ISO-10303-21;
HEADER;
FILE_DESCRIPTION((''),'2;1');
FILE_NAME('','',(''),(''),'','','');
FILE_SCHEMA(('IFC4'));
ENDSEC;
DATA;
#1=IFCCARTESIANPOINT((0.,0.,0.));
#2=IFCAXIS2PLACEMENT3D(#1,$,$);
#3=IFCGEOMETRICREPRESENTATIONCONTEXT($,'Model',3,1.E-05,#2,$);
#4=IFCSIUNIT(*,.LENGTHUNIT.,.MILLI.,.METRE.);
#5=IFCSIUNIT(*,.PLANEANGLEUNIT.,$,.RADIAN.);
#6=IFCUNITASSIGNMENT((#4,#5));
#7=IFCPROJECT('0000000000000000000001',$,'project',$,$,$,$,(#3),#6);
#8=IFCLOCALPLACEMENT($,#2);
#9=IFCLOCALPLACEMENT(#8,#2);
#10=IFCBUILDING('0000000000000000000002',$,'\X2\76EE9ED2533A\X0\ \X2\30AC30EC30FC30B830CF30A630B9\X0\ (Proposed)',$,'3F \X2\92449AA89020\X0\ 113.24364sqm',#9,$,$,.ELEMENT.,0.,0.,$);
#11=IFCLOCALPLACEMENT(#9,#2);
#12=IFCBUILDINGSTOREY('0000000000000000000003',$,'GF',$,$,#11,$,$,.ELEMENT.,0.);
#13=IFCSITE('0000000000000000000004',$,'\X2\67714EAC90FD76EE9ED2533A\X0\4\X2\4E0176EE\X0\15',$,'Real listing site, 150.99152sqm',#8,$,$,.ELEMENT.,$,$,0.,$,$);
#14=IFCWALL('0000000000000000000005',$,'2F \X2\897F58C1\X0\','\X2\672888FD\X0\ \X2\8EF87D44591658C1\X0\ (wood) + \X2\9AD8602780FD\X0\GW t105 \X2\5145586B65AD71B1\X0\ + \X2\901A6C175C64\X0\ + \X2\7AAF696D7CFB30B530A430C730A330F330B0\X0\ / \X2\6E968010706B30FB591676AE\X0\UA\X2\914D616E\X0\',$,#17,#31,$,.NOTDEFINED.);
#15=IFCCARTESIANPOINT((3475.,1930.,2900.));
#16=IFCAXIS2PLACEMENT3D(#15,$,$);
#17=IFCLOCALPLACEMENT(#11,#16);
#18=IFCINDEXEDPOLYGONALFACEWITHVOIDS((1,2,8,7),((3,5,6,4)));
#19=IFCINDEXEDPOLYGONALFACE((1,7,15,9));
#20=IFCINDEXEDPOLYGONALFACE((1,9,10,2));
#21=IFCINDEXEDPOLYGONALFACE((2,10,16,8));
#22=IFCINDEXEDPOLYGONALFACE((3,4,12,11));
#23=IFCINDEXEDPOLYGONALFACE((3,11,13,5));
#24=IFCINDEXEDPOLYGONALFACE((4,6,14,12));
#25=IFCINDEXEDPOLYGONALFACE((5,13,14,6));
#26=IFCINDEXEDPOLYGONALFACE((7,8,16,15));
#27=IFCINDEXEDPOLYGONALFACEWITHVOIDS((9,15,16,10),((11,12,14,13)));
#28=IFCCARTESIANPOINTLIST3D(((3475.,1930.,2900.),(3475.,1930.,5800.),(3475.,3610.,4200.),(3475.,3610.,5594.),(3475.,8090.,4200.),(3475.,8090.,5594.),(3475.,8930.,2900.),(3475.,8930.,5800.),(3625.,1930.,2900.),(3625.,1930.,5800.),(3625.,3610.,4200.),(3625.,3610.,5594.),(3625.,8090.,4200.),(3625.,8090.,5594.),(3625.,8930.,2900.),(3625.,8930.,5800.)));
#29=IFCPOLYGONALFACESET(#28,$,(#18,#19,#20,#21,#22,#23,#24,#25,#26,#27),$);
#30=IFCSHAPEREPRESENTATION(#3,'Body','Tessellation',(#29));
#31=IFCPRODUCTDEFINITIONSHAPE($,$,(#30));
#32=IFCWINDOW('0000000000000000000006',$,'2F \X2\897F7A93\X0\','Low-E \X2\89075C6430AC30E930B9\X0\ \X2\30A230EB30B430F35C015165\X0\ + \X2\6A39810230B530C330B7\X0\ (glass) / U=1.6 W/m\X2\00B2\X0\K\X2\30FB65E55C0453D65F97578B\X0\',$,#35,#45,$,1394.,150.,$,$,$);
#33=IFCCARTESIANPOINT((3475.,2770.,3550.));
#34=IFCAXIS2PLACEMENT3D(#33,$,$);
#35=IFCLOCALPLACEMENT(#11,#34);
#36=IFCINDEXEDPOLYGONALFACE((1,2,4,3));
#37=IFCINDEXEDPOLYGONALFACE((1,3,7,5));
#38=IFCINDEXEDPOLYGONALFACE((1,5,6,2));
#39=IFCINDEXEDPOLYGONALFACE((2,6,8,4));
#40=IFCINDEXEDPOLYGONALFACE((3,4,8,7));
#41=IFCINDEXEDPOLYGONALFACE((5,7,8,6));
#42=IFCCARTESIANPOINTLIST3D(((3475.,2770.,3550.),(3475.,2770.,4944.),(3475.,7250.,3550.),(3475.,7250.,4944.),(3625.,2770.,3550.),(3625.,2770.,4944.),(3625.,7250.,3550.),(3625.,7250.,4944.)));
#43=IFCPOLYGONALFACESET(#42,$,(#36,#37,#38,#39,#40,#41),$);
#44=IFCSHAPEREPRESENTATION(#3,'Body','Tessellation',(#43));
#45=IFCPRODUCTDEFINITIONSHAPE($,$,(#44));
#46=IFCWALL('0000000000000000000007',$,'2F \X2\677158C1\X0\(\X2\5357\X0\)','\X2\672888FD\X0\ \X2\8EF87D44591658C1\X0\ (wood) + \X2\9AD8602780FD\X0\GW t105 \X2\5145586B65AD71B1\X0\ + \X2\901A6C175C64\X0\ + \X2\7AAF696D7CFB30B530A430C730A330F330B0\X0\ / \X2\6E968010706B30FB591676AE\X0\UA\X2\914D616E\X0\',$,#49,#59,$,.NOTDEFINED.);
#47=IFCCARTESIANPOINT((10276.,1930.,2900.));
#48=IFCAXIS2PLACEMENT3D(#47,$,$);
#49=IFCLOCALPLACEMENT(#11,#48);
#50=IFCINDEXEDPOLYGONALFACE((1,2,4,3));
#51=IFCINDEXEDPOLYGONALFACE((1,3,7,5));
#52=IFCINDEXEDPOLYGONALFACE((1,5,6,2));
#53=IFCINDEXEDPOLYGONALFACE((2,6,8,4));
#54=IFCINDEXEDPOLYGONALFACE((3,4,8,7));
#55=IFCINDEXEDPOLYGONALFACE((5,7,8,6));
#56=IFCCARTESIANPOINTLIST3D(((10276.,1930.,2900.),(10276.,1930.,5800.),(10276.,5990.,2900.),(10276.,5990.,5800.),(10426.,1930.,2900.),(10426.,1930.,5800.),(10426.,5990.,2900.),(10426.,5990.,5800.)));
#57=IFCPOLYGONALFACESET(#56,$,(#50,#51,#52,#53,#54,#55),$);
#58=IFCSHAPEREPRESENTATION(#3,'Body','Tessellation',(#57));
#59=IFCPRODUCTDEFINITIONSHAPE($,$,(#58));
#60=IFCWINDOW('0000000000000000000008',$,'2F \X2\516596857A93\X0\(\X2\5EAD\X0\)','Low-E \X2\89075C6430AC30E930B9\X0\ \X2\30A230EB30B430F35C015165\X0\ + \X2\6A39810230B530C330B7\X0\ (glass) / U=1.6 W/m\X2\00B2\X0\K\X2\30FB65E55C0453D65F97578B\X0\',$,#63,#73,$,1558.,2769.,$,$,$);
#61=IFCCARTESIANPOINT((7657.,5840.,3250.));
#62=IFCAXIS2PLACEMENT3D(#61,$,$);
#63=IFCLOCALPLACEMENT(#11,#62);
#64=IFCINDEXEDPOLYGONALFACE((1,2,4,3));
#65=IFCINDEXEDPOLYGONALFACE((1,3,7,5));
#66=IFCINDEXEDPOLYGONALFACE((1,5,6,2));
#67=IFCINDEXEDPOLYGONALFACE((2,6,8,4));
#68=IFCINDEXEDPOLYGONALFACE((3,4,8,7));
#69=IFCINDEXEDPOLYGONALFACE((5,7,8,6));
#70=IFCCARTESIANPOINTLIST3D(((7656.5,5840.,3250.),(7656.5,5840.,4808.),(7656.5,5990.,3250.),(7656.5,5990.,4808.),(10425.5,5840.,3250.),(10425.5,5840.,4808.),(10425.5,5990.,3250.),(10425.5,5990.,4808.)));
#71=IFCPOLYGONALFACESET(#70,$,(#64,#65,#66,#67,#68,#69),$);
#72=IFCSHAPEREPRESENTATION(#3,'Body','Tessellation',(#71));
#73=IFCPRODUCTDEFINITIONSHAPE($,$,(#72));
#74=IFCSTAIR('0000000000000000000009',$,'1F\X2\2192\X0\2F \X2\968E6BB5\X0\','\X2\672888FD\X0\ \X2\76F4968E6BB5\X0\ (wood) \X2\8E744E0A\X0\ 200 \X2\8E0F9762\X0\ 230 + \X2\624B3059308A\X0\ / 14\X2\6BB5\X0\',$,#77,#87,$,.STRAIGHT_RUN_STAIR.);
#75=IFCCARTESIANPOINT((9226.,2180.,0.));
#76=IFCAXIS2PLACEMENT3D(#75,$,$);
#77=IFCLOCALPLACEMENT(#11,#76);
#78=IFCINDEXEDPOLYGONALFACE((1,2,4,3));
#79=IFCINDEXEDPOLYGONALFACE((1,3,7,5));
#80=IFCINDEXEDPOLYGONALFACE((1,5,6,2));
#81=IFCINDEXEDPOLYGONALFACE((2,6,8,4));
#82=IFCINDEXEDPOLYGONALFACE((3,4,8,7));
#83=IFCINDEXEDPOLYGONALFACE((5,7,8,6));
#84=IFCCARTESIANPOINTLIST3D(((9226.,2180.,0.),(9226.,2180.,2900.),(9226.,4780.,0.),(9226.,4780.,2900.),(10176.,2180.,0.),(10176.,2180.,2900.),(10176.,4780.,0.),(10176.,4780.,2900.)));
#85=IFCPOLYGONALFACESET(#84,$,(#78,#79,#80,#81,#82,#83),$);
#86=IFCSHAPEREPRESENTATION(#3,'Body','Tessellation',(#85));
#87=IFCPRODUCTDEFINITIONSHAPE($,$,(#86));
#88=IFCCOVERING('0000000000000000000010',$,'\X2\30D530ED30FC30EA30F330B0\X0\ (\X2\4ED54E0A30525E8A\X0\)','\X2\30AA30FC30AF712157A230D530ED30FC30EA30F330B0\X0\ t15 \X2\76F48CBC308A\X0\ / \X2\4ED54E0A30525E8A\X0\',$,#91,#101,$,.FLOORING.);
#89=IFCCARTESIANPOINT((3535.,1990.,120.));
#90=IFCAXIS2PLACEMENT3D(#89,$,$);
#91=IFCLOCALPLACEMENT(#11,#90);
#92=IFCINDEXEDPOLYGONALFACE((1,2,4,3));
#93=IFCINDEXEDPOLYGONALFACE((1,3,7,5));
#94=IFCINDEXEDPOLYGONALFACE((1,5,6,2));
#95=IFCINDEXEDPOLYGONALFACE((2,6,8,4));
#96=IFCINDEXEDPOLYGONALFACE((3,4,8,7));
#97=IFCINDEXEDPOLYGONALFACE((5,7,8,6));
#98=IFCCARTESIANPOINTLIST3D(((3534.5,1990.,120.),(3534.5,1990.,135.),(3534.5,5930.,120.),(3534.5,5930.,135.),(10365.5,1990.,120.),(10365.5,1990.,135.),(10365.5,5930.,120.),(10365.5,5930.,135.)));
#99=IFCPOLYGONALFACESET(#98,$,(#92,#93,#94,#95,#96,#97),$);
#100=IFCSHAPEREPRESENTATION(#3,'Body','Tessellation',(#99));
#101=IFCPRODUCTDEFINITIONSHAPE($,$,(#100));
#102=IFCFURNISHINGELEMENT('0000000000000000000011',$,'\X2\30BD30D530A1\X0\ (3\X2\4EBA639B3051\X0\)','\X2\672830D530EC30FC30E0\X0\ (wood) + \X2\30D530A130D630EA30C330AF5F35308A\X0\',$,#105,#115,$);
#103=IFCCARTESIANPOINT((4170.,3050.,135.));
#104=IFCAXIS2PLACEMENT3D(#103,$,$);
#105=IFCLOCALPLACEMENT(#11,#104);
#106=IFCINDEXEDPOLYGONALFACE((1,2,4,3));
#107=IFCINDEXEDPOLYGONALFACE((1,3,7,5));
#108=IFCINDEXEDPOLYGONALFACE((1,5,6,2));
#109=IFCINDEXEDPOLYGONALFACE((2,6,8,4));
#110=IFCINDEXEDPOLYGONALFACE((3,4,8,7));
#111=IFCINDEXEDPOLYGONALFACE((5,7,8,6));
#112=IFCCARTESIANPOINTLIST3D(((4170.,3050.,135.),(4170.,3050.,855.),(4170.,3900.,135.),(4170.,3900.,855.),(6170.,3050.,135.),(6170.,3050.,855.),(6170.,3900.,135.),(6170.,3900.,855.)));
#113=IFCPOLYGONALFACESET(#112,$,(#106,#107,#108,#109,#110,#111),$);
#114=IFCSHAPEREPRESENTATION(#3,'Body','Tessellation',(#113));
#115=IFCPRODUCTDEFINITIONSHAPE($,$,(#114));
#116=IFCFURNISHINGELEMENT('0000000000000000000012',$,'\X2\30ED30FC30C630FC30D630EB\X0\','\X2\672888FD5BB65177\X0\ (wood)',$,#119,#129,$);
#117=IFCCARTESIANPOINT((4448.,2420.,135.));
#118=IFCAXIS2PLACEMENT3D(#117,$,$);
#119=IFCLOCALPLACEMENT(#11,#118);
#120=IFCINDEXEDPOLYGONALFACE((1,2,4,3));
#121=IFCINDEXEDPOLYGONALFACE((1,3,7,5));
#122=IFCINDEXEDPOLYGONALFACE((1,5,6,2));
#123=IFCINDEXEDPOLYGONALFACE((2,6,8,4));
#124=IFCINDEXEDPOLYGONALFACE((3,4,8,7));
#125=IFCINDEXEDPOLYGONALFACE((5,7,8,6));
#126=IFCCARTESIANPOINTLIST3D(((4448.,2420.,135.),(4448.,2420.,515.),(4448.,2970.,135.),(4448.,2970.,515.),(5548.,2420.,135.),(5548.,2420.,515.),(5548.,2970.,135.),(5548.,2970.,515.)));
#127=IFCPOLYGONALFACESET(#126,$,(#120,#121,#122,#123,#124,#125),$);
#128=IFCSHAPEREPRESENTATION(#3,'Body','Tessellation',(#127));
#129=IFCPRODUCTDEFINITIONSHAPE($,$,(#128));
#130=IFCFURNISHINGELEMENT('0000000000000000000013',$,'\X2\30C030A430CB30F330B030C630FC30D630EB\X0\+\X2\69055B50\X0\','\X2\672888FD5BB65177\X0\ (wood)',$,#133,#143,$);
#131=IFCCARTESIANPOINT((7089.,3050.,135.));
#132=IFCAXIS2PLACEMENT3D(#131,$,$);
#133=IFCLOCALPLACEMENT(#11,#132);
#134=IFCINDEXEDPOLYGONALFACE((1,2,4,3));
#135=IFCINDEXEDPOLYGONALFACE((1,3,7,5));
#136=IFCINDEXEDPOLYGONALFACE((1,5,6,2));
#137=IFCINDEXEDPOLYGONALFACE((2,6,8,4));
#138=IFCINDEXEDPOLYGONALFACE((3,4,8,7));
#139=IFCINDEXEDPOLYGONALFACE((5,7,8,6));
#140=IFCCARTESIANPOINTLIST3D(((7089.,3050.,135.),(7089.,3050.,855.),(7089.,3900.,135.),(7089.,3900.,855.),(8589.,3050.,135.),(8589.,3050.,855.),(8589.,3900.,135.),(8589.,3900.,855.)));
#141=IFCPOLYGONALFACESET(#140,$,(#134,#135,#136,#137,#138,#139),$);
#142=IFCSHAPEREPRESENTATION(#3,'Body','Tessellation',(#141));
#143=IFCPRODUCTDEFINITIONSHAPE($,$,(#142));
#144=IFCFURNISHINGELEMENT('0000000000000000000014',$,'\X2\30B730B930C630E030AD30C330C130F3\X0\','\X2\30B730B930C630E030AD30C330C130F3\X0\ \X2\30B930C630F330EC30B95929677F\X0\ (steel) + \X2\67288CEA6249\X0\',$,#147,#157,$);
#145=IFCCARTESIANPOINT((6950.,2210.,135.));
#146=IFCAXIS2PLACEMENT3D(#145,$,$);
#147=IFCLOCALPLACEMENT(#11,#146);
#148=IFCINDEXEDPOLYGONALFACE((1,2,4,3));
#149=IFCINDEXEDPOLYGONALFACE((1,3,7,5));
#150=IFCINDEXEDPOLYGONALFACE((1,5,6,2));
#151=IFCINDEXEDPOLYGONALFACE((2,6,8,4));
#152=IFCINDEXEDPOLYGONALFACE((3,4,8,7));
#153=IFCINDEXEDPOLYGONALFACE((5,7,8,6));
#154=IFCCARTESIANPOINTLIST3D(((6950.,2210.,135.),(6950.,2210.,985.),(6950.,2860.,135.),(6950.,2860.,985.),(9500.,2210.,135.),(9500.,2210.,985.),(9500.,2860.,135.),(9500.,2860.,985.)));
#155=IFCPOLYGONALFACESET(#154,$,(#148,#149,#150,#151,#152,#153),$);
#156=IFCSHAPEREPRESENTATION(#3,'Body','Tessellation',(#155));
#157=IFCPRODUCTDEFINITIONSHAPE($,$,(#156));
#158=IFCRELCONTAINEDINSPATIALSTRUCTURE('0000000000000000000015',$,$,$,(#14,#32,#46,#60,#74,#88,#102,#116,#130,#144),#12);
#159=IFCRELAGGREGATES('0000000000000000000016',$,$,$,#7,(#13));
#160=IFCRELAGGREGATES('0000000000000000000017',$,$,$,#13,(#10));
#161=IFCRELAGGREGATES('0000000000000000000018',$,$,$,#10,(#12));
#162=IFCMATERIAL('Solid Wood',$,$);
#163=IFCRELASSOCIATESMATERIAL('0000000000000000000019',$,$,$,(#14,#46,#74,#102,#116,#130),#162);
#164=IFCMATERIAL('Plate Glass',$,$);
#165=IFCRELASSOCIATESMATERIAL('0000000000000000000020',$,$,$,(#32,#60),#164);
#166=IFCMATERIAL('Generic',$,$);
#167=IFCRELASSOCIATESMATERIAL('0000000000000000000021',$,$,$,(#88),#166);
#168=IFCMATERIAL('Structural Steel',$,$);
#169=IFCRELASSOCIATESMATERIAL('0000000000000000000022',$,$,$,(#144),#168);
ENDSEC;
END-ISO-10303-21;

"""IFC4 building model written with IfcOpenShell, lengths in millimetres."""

from ifc_helpers import new_model, si_unit, frame, frame_2d, origin, place, context, project, spatial, rectangle, extrude, material, element, fill, save


model = new_model("IFC4")

# Units and contexts
model_context = context("Model", 3, precision=1e-05, world=origin())
ifc_project = project(units=[si_unit("LENGTHUNIT", "METRE", prefix="MILLI"), si_unit("PLANEANGLEUNIT", "RADIAN")], contexts=[model_context])

# Site, building, storey
site_placement = place(None, origin())
site = spatial("IfcSite", under=ifc_project, at=site_placement, Name="東京都目黒区4丁目15", ObjectType="Real listing site, 150.99152sqm", CompositionType="ELEMENT", RefElevation=0.0)
building_placement = place(site_placement, origin())
building = spatial("IfcBuilding", under=site, at=building_placement, Name="目黒区 ガレージハウス (Proposed)", ObjectType="3F 鉄骨造 113.24364sqm", CompositionType="ELEMENT", ElevationOfRefHeight=0.0, ElevationOfTerrain=0.0)
storey_placement = place(building_placement, origin())
storey = spatial("IfcBuildingStorey", under=building, at=storey_placement, Name="GF", CompositionType="ELEMENT", Elevation=0.0)

# Shared definitions
ifc_material_1 = material(Name="Solid Wood")

# Shared definitions
ifc_material_2 = material(Name="Plate Glass")

# Walls, openings, windows
wall_1_placement = place(storey_placement, frame((3475.0, 1930.0, 2900.0)))
wall_1 = element("IfcWall", 1, at=wall_1_placement, inside=storey, material=ifc_material_1, Name="2F 西壁", Description="木製 軸組外壁 (wood) + 高性能GW t105 充填断熱 + 通気層 + 窯業系サイディング / 準耐火・外皮UA配慮", PredefinedType="NOTDEFINED", context=model_context, shape_type="SweptSolid", body=[
    extrude(rectangle(XDim=150.0, YDim=7000.0, at=frame_2d((75.0, 3500.0))), frame((3475.0, 1930.0, 2900.0)), (0.0, 0.0, 1.0), 2900.0),
])
opening_1_placement = place(storey_placement, frame((3475.0, 2770.0, 3550.0)))
opening_1 = element("IfcOpeningElement", 2, at=opening_1_placement, cuts=wall_1, PredefinedType="NOTDEFINED", context=model_context, shape_type="SweptSolid", body=[
    extrude(rectangle(XDim=150.0, YDim=4480.0, at=frame_2d((75.0, 2240.0))), frame((3475.0, 2770.0, 3550.0)), (0.0, 0.0, 1.0), 1394.0),
])
window_1_placement = place(storey_placement, frame((3475.0, 2770.0, 3550.0)))
window_1 = element("IfcWindow", 3, at=window_1_placement, inside=storey, material=ifc_material_2, Name="2F 西窓", Description="Low-E 複層ガラス アルゴン封入 + 樹脂サッシ (glass) / U=1.6 W/m²K・日射取得型", OverallHeight=1394.0, OverallWidth=150.0, context=model_context, shape_type="SweptSolid", body=[
    extrude(rectangle(XDim=150.0, YDim=4480.0, at=frame_2d((75.0, 2240.0))), frame((3475.0, 2770.0, 3550.0)), (0.0, 0.0, 1.0), 1394.0),
])
fill(opening_1, window_1)
wall_2_placement = place(storey_placement, frame((10276.0, 1930.0, 2900.0)))
wall_2 = element("IfcWall", 4, at=wall_2_placement, inside=storey, material=ifc_material_1, Name="2F 東壁(南)", Description="木製 軸組外壁 (wood) + 高性能GW t105 充填断熱 + 通気層 + 窯業系サイディング / 準耐火・外皮UA配慮", PredefinedType="NOTDEFINED", context=model_context, shape_type="SweptSolid", body=[
    extrude(rectangle(XDim=150.0, YDim=4060.0, at=frame_2d((75.0, 2030.0))), frame((10276.0, 1930.0, 2900.0)), (0.0, 0.0, 1.0), 2900.0),
])
opening_2_placement = place(storey_placement, frame((7657.0, 5840.0, 3250.0)))
opening_2 = element("IfcOpeningElement", 5, at=opening_2_placement, cuts=wall_2, PredefinedType="NOTDEFINED", context=model_context, shape_type="SweptSolid", body=[
    extrude(rectangle(XDim=2769.0, YDim=150.0, at=frame_2d((1384.0, 75.0))), frame((7657.0, 5840.0, 3250.0)), (0.0, 0.0, 1.0), 1558.0),
])
window_2_placement = place(storey_placement, frame((7657.0, 5840.0, 3250.0)))
window_2 = element("IfcWindow", 6, at=window_2_placement, inside=storey, material=ifc_material_2, Name="2F 入隅窓(庭)", Description="Low-E 複層ガラス アルゴン封入 + 樹脂サッシ (glass) / U=1.6 W/m²K・日射取得型", OverallHeight=1558.0, OverallWidth=2769.0, context=model_context, shape_type="SweptSolid", body=[
    extrude(rectangle(XDim=2769.0, YDim=150.0, at=frame_2d((1384.0, 75.0))), frame((7657.0, 5840.0, 3250.0)), (0.0, 0.0, 1.0), 1558.0),
])
fill(opening_2, window_2)

# Stair
stair_placement = place(storey_placement, frame((9226.0, 2180.0, 0.0)))
element("IfcStair", 7, at=stair_placement, inside=storey, material=ifc_material_1, Name="1F→2F 階段", Description="木製 直階段 (wood) 蹴上 200 踏面 230 + 手すり / 14段", PredefinedType="STRAIGHT_RUN_STAIR", context=model_context, shape_type="SweptSolid", body=[
    extrude(rectangle(XDim=950.0, YDim=2600.0, at=frame_2d((475.0, 1300.0))), frame((9226.0, 2180.0, 0.0)), (0.0, 0.0, 1.0), 2900.0),
])

# Covering
ifc_material_3 = material(Name="Generic")
covering_placement = place(storey_placement, frame((3535.0, 1990.0, 120.0)))
element("IfcCovering", 8, at=covering_placement, inside=storey, material=ifc_material_3, Name="フローリング (仕上げ床)", Description="オーク無垢フローリング t15 直貼り / 仕上げ床", PredefinedType="FLOORING", context=model_context, shape_type="SweptSolid", body=[
    extrude(rectangle(XDim=6831.0, YDim=3940.0, at=frame_2d((3415.0, 1970.0))), frame((3535.0, 1990.0, 120.0)), (0.0, 0.0, 1.0), 15.0),
])

# Furnishing elements
furnishing_1_placement = place(storey_placement, frame((4170.0, 3050.0, 135.0)))
element("IfcFurnishingElement", 9, at=furnishing_1_placement, inside=storey, material=ifc_material_1, Name="ソファ (3人掛け)", Description="木フレーム (wood) + ファブリック張り", context=model_context, shape_type="SweptSolid", body=[
    extrude(rectangle(XDim=2000.0, YDim=850.0, at=frame_2d((1000.0, 425.0))), frame((4170.0, 3050.0, 135.0)), (0.0, 0.0, 1.0), 720.0),
])
furnishing_2_placement = place(storey_placement, frame((4448.0, 2420.0, 135.0)))
element("IfcFurnishingElement", 10, at=furnishing_2_placement, inside=storey, material=ifc_material_1, Name="ローテーブル", Description="木製家具 (wood)", context=model_context, shape_type="SweptSolid", body=[
    extrude(rectangle(XDim=1100.0, YDim=550.0, at=frame_2d((550.0, 275.0))), frame((4448.0, 2420.0, 135.0)), (0.0, 0.0, 1.0), 380.0),
])
furnishing_3_placement = place(storey_placement, frame((7089.0, 3050.0, 135.0)))
element("IfcFurnishingElement", 11, at=furnishing_3_placement, inside=storey, material=ifc_material_1, Name="ダイニングテーブル+椅子", Description="木製家具 (wood)", context=model_context, shape_type="SweptSolid", body=[
    extrude(rectangle(XDim=1500.0, YDim=850.0, at=frame_2d((750.0, 425.0))), frame((7089.0, 3050.0, 135.0)), (0.0, 0.0, 1.0), 720.0),
])
ifc_material_4 = material(Name="Structural Steel")
furnishing_4_placement = place(storey_placement, frame((6950.0, 2210.0, 135.0)))
element("IfcFurnishingElement", 12, at=furnishing_4_placement, inside=storey, material=ifc_material_4, Name="システムキッチン", Description="システムキッチン ステンレス天板 (steel) + 木質扉", context=model_context, shape_type="SweptSolid", body=[
    extrude(rectangle(XDim=2550.0, YDim=650.0, at=frame_2d((1275.0, 325.0))), frame((6950.0, 2210.0, 135.0)), (0.0, 0.0, 1.0), 850.0),
])

save(model, "model.ifc")
